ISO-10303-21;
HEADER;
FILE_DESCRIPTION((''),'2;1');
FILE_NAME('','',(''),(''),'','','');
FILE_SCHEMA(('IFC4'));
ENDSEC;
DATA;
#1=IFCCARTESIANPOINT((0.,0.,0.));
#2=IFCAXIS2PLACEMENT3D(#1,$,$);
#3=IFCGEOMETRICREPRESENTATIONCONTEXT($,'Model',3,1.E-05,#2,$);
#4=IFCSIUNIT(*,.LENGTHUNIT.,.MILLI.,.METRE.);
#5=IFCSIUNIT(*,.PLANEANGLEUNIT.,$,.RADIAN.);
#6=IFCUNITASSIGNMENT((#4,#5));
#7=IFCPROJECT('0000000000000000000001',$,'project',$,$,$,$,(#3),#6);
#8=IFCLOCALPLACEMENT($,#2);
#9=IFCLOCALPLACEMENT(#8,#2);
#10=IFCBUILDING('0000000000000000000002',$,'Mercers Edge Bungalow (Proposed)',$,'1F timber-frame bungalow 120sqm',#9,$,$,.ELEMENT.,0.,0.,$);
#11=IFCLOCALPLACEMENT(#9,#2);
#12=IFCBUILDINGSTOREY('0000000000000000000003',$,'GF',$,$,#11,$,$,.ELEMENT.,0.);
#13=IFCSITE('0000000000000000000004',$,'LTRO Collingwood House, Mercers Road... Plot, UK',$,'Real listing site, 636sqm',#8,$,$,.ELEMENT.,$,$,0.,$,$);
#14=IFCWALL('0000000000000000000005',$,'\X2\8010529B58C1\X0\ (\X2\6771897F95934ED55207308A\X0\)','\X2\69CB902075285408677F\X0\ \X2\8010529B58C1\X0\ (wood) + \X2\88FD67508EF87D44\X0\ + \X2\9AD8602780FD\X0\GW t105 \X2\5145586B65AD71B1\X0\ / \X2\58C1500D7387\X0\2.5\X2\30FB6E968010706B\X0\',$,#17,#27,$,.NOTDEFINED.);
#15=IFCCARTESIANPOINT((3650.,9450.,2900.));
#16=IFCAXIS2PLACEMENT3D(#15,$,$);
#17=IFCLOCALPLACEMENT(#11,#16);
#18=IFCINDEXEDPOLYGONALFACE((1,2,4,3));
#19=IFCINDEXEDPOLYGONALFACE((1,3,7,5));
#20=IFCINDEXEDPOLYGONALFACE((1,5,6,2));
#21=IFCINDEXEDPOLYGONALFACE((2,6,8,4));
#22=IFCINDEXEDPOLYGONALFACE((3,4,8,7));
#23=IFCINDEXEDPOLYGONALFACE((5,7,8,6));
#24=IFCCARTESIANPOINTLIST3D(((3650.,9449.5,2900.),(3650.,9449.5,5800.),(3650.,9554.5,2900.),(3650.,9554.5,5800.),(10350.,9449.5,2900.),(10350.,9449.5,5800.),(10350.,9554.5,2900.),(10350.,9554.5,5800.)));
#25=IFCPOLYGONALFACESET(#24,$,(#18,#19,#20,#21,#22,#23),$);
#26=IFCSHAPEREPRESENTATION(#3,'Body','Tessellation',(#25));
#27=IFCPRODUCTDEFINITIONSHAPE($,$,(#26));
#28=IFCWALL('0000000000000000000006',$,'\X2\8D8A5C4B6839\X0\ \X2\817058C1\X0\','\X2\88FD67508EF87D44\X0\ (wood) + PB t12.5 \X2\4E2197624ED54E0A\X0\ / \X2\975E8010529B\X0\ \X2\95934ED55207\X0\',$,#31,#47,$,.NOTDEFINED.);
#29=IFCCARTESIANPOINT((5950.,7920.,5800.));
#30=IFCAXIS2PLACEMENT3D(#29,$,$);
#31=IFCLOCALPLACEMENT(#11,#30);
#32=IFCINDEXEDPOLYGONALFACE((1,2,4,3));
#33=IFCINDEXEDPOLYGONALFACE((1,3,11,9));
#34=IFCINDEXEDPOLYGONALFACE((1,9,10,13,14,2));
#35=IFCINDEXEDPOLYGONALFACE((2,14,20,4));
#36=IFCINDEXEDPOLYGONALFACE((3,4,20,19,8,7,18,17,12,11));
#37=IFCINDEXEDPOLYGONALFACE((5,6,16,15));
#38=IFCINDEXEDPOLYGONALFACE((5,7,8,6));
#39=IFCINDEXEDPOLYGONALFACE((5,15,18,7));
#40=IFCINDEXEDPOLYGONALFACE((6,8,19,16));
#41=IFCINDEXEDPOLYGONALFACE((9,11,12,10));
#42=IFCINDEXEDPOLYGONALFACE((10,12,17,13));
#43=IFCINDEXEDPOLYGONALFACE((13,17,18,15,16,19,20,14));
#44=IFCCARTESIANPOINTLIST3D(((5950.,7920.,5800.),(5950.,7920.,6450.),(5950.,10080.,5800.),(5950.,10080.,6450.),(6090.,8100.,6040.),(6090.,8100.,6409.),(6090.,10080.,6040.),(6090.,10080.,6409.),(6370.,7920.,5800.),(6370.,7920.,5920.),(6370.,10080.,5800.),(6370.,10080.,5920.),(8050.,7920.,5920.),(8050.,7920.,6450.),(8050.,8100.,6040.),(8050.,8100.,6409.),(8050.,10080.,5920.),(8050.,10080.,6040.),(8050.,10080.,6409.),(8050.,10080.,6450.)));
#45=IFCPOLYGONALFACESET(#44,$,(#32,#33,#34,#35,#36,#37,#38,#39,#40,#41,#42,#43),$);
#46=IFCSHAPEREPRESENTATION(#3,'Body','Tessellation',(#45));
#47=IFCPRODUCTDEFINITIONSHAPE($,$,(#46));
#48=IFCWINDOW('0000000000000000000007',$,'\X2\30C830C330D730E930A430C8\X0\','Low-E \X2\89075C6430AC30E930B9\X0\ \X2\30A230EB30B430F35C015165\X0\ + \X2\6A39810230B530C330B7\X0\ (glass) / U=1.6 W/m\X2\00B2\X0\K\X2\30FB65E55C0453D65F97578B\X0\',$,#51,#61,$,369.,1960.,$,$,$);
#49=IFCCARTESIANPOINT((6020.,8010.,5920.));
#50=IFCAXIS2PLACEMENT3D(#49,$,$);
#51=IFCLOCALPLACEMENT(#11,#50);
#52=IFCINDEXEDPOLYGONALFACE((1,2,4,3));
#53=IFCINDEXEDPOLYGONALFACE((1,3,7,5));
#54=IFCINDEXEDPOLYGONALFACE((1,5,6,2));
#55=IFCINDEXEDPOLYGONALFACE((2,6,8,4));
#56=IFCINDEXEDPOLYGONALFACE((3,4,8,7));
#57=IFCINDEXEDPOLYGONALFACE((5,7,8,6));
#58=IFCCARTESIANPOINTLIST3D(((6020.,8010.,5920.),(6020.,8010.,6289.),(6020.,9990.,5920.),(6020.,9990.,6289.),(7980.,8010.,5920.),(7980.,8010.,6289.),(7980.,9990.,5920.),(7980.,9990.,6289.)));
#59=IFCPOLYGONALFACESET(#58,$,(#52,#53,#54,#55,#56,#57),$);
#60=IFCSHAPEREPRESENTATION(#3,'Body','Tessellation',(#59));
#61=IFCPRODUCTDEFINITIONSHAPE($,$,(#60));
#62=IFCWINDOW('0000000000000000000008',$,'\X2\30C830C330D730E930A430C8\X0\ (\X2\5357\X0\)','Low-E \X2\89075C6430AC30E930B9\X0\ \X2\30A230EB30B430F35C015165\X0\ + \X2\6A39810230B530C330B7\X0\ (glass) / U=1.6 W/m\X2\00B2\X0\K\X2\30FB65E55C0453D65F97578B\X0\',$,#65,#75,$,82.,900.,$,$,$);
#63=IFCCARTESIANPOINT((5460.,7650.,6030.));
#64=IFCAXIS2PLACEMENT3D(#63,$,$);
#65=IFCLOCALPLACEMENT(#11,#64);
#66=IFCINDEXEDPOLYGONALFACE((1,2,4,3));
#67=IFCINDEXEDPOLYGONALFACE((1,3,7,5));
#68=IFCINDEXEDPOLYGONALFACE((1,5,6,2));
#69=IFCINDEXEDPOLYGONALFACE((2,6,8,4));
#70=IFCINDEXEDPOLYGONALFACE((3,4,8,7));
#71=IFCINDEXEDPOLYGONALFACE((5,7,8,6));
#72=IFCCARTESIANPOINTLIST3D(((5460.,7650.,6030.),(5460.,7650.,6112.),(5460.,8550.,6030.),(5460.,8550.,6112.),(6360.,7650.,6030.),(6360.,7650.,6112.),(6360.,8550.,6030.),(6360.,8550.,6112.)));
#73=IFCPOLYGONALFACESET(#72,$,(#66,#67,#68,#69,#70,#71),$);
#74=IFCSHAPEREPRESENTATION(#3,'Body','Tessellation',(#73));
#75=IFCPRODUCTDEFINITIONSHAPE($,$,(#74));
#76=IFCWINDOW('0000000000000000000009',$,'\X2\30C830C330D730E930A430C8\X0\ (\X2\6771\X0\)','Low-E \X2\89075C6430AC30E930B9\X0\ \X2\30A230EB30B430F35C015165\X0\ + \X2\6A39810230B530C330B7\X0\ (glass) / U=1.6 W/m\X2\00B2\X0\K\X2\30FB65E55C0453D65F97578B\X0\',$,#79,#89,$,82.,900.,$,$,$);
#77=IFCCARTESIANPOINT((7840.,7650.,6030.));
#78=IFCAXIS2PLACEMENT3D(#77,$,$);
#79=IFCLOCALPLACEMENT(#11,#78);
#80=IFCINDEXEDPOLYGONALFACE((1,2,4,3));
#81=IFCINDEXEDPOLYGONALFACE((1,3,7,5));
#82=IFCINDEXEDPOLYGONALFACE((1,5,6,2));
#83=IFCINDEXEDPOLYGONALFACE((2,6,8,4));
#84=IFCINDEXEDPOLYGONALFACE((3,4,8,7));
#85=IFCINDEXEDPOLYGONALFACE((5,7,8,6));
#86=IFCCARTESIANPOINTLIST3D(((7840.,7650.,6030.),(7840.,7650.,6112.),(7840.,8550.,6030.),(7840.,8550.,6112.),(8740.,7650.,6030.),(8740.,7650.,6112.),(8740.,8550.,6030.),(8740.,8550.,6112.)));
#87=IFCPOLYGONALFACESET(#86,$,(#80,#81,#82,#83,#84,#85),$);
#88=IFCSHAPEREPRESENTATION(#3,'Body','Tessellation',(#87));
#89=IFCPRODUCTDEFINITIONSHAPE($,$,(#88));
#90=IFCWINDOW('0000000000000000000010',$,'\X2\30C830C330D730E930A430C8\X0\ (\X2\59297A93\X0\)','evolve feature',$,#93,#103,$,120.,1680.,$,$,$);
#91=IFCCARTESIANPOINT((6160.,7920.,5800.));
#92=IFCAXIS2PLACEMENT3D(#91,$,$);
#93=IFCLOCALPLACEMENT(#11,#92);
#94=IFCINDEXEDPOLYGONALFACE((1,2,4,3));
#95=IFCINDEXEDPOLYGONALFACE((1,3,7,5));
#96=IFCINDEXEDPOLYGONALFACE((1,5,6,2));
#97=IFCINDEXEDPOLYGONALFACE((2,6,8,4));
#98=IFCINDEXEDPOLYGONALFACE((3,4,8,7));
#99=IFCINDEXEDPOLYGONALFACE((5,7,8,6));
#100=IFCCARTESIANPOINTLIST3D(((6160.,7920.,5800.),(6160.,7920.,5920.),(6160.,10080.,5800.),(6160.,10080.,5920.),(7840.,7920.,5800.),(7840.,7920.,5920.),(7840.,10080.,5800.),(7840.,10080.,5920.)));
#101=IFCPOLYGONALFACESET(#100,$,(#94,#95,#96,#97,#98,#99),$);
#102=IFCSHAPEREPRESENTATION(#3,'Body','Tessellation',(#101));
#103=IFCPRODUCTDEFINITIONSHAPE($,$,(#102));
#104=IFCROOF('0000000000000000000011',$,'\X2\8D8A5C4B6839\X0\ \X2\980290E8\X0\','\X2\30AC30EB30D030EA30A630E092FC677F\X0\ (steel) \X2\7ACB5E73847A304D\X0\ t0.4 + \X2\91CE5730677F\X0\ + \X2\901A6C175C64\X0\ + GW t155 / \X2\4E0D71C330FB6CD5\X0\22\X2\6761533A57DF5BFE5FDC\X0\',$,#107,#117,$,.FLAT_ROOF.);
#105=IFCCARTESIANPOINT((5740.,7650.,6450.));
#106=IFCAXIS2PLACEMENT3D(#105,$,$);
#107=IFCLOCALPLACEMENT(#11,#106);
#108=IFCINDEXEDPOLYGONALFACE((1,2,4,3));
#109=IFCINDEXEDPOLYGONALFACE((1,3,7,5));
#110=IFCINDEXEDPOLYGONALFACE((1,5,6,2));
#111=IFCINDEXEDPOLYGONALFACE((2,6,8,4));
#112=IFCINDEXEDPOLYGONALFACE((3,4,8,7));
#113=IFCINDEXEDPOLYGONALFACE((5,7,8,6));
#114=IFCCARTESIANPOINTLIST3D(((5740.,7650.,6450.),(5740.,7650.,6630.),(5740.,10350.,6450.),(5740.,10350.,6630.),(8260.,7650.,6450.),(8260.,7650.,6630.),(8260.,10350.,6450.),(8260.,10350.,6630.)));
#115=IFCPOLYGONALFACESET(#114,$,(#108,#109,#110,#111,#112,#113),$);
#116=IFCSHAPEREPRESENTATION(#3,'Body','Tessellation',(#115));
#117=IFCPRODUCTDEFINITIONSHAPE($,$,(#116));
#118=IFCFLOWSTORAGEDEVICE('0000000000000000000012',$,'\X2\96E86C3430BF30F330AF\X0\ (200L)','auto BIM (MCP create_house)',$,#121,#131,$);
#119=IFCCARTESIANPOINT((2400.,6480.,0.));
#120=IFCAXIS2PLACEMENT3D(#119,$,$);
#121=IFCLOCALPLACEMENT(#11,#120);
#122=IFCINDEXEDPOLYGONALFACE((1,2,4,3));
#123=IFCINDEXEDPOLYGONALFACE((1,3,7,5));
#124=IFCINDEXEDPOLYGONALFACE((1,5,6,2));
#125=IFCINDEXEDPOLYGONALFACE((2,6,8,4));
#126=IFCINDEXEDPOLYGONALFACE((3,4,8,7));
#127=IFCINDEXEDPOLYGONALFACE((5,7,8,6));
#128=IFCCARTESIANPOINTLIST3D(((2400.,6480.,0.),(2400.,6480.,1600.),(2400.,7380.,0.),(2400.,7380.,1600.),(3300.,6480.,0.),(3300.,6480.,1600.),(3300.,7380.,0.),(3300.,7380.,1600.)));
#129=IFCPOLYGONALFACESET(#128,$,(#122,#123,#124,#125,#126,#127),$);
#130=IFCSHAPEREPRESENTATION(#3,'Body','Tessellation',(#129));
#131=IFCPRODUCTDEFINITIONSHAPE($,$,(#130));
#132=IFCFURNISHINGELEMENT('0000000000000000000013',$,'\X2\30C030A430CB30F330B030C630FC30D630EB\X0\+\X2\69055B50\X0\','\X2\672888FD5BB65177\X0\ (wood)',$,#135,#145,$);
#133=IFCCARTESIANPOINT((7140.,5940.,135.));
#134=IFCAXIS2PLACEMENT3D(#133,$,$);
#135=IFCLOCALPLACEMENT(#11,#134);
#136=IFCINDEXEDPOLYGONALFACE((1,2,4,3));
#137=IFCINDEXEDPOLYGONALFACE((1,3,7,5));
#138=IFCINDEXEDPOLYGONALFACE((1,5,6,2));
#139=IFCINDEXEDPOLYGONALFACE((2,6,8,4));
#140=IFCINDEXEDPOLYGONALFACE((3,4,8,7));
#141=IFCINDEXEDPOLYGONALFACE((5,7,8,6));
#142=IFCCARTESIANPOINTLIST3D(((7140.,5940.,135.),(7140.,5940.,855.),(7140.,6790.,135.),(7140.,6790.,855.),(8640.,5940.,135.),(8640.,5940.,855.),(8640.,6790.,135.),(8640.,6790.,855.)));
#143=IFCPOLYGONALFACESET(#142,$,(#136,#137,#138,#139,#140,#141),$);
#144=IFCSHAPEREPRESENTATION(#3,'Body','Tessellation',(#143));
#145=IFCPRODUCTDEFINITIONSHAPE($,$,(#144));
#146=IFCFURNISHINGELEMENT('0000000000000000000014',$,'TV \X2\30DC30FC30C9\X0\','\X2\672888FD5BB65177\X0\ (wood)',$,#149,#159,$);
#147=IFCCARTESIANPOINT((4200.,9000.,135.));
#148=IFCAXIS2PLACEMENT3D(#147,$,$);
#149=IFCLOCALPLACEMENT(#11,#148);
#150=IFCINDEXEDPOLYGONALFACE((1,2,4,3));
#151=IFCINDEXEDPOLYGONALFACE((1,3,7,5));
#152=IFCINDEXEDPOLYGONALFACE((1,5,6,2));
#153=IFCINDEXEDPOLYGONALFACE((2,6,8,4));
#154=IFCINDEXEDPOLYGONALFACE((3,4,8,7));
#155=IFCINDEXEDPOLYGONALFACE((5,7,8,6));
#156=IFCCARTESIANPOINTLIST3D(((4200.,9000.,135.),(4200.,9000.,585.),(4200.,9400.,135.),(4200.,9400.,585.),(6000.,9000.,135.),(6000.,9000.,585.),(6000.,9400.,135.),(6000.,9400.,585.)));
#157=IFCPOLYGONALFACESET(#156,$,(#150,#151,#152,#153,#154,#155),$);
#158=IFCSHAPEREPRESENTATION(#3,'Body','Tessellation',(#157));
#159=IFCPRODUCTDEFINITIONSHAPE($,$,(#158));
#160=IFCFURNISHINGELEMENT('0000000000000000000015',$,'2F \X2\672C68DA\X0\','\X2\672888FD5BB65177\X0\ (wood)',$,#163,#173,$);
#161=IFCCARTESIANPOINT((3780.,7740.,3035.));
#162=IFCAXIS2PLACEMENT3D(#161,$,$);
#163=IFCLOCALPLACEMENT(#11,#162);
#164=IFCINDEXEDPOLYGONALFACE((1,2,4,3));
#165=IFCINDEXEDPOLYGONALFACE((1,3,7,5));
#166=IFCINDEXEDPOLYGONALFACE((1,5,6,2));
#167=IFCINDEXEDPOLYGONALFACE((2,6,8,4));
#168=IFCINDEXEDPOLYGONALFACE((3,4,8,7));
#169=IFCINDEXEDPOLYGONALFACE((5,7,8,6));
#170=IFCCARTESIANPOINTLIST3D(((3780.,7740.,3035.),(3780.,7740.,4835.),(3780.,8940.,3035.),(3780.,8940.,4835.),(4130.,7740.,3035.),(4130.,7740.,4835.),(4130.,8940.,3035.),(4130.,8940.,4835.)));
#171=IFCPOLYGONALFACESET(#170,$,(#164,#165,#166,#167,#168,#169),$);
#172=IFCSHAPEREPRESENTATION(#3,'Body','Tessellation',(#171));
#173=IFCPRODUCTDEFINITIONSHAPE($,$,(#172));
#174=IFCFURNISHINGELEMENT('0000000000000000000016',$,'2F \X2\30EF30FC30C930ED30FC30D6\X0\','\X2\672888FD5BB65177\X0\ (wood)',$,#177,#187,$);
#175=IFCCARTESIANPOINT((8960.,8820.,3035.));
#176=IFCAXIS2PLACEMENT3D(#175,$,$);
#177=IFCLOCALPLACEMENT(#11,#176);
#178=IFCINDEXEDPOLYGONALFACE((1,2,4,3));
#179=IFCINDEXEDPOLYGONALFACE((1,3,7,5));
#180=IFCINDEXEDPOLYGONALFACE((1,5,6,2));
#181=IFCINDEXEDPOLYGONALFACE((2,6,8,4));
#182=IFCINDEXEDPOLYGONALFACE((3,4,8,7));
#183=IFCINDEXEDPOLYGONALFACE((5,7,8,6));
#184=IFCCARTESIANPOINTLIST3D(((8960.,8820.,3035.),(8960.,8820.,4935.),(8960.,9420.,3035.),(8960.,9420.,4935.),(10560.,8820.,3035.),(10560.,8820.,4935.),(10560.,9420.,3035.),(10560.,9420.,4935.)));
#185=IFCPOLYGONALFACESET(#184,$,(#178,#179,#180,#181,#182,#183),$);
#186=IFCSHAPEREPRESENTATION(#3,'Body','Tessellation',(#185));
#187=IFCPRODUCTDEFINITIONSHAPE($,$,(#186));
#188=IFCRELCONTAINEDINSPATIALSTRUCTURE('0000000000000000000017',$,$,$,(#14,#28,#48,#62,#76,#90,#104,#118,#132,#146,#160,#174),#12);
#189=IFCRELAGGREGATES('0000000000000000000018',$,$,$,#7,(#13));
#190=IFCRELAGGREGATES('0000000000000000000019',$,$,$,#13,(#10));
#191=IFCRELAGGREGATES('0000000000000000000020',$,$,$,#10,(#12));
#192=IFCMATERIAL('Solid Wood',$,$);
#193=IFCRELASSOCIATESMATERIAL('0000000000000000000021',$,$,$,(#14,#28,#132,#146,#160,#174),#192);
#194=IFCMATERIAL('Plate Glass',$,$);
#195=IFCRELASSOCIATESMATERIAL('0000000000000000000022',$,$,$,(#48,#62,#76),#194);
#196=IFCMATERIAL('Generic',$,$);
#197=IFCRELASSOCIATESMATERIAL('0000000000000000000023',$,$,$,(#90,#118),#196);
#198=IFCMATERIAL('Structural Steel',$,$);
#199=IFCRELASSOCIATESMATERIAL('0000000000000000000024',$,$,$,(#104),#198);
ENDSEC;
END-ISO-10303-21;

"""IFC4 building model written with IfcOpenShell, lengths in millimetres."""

from ifc_helpers import new_model, si_unit, frame, frame_2d, origin, place, context, project, spatial, rectangle, extrude, material, element, fill, save


model = new_model("IFC4")

# Units and contexts
model_context = context("Model", 3, precision=1e-05, world=origin())
ifc_project = project(units=[si_unit("LENGTHUNIT", "METRE", prefix="MILLI"), si_unit("PLANEANGLEUNIT", "RADIAN")], contexts=[model_context])

# Site, building, storey
site_placement = place(None, origin())
site = spatial("IfcSite", under=ifc_project, at=site_placement, Name="LTRO Collingwood House, Mercers Road... Plot, UK", ObjectType="Real listing site, 636sqm", CompositionType="ELEMENT", RefElevation=0.0)
building_placement = place(site_placement, origin())
building = spatial("IfcBuilding", under=site, at=building_placement, Name="Mercers Edge Bungalow (Proposed)", ObjectType="1F timber-frame bungalow 120sqm", CompositionType="ELEMENT", ElevationOfRefHeight=0.0, ElevationOfTerrain=0.0)
storey_placement = place(building_placement, origin())
storey = spatial("IfcBuildingStorey", under=building, at=storey_placement, Name="GF", CompositionType="ELEMENT", Elevation=0.0)

# Wall
ifc_material_1 = material(Name="Solid Wood")
wall_1_placement = place(storey_placement, frame((3650.0, 9450.0, 2900.0)))
element("IfcWall", 1, at=wall_1_placement, inside=storey, material=ifc_material_1, Name="耐力壁 (東西間仕切り)", Description="構造用合板 耐力壁 (wood) + 製材軸組 + 高性能GW t105 充填断熱 / 壁倍率2.5・準耐火", PredefinedType="NOTDEFINED", context=model_context, shape_type="SweptSolid", body=[
    extrude(rectangle(XDim=6700.0, YDim=105.0, at=frame_2d((3350.0, 52.0))), frame((3650.0, 9450.0, 2900.0)), (0.0, 0.0, 1.0), 2900.0),
])

# Wall, openings, windows
wall_2_placement = place(storey_placement, frame((5950.0, 7920.0, 5800.0)))
wall_2 = element("IfcWall", 2, at=wall_2_placement, inside=storey, material=ifc_material_1, Name="越屋根 腰壁", Description="製材軸組 (wood) + PB t12.5 両面仕上 / 非耐力 間仕切", PredefinedType="NOTDEFINED", context=model_context, shape_type="SweptSolid", body=[
    extrude(rectangle(XDim=2100.0, YDim=2160.0, at=frame_2d((1050.0, 1080.0))), frame((5950.0, 7920.0, 5800.0)), (0.0, 0.0, 1.0), 650.0),
])
opening_1_placement = place(storey_placement, frame((6020.0, 8010.0, 5920.0)))
opening_1 = element("IfcOpeningElement", 3, at=opening_1_placement, cuts=wall_2, PredefinedType="NOTDEFINED", context=model_context, shape_type="SweptSolid", body=[
    extrude(rectangle(XDim=1960.0, YDim=1980.0, at=frame_2d((980.0, 990.0))), frame((6020.0, 8010.0, 5920.0)), (0.0, 0.0, 1.0), 369.0),
])
opening_2_placement = place(storey_placement, frame((5460.0, 7650.0, 6030.0)))
opening_2 = element("IfcOpeningElement", 4, at=opening_2_placement, cuts=wall_2, PredefinedType="NOTDEFINED", context=model_context, shape_type="SweptSolid", body=[
    extrude(rectangle(XDim=900.0, YDim=900.0, at=frame_2d((450.0, 450.0))), frame((5460.0, 7650.0, 6030.0)), (0.0, 0.0, 1.0), 82.0),
])
opening_3_placement = place(storey_placement, frame((7840.0, 7650.0, 6030.0)))
opening_3 = element("IfcOpeningElement", 5, at=opening_3_placement, cuts=wall_2, PredefinedType="NOTDEFINED", context=model_context, shape_type="SweptSolid", body=[
    extrude(rectangle(XDim=900.0, YDim=900.0, at=frame_2d((450.0, 450.0))), frame((7840.0, 7650.0, 6030.0)), (0.0, 0.0, 1.0), 82.0),
])
opening_4_placement = place(storey_placement, frame((6160.0, 7920.0, 5800.0)))
opening_4 = element("IfcOpeningElement", 6, at=opening_4_placement, cuts=wall_2, PredefinedType="NOTDEFINED", context=model_context, shape_type="SweptSolid", body=[
    extrude(rectangle(XDim=1680.0, YDim=2160.0, at=frame_2d((840.0, 1080.0))), frame((6160.0, 7920.0, 5800.0)), (0.0, 0.0, 1.0), 120.0),
])
ifc_material_2 = material(Name="Plate Glass")
window_1_placement = place(storey_placement, frame((6020.0, 8010.0, 5920.0)))
window_1 = element("IfcWindow", 7, at=window_1_placement, inside=storey, material=ifc_material_2, Name="トップライト", Description="Low-E 複層ガラス アルゴン封入 + 樹脂サッシ (glass) / U=1.6 W/m²K・日射取得型", OverallHeight=369.0, OverallWidth=1960.0, context=model_context, shape_type="SweptSolid", body=[
    extrude(rectangle(XDim=1960.0, YDim=1980.0, at=frame_2d((980.0, 990.0))), frame((6020.0, 8010.0, 5920.0)), (0.0, 0.0, 1.0), 369.0),
])
fill(opening_1, window_1)
window_2_placement = place(storey_placement, frame((5460.0, 7650.0, 6030.0)))
window_2 = element("IfcWindow", 8, at=window_2_placement, inside=storey, material=ifc_material_2, Name="トップライト (南)", Description="Low-E 複層ガラス アルゴン封入 + 樹脂サッシ (glass) / U=1.6 W/m²K・日射取得型", OverallHeight=82.0, OverallWidth=900.0, context=model_context, shape_type="SweptSolid", body=[
    extrude(rectangle(XDim=900.0, YDim=900.0, at=frame_2d((450.0, 450.0))), frame((5460.0, 7650.0, 6030.0)), (0.0, 0.0, 1.0), 82.0),
])
fill(opening_2, window_2)
window_3_placement = place(storey_placement, frame((7840.0, 7650.0, 6030.0)))
window_3 = element("IfcWindow", 9, at=window_3_placement, inside=storey, material=ifc_material_2, Name="トップライト (東)", Description="Low-E 複層ガラス アルゴン封入 + 樹脂サッシ (glass) / U=1.6 W/m²K・日射取得型", OverallHeight=82.0, OverallWidth=900.0, context=model_context, shape_type="SweptSolid", body=[
    extrude(rectangle(XDim=900.0, YDim=900.0, at=frame_2d((450.0, 450.0))), frame((7840.0, 7650.0, 6030.0)), (0.0, 0.0, 1.0), 82.0),
])
fill(opening_3, window_3)
ifc_material_3 = material(Name="Generic")
window_4_placement = place(storey_placement, frame((6160.0, 7920.0, 5800.0)))
window_4 = element("IfcWindow", 10, at=window_4_placement, inside=storey, material=ifc_material_3, Name="トップライト (天窓)", Description="evolve feature", OverallHeight=120.0, OverallWidth=1680.0, context=model_context, shape_type="SweptSolid", body=[
    extrude(rectangle(XDim=1680.0, YDim=2160.0, at=frame_2d((840.0, 1080.0))), frame((6160.0, 7920.0, 5800.0)), (0.0, 0.0, 1.0), 120.0),
])
fill(opening_4, window_4)

# Roof
ifc_material_4 = material(Name="Structural Steel")
roof_placement = place(storey_placement, frame((5740.0, 7650.0, 6450.0)))
element("IfcRoof", 11, at=roof_placement, inside=storey, material=ifc_material_4, Name="越屋根 頂部", Description="ガルバリウム鋼板 (steel) 立平葺き t0.4 + 野地板 + 通気層 + GW t155 / 不燃・法22条区域対応", PredefinedType="FLAT_ROOF", context=model_context, shape_type="SweptSolid", body=[
    extrude(rectangle(XDim=2520.0, YDim=2700.0, at=frame_2d((1260.0, 1350.0))), frame((5740.0, 7650.0, 6450.0)), (0.0, 0.0, 1.0), 180.0),
])

# Flow storage device
flow_storage_device_placement = place(storey_placement, frame((2400.0, 6480.0, 0.0)))
element("IfcFlowStorageDevice", 12, at=flow_storage_device_placement, inside=storey, material=ifc_material_3, Name="雨水タンク (200L)", Description="auto BIM (MCP create_house)", context=model_context, shape_type="SweptSolid", body=[
    extrude(rectangle(XDim=900.0, YDim=900.0, at=frame_2d((450.0, 450.0))), frame((2400.0, 6480.0, 0.0)), (0.0, 0.0, 1.0), 1600.0),
])

# Furnishing elements
furnishing_1_placement = place(storey_placement, frame((7140.0, 5940.0, 135.0)))
element("IfcFurnishingElement", 13, at=furnishing_1_placement, inside=storey, material=ifc_material_1, Name="ダイニングテーブル+椅子", Description="木製家具 (wood)", context=model_context, shape_type="SweptSolid", body=[
    extrude(rectangle(XDim=1500.0, YDim=850.0, at=frame_2d((750.0, 425.0))), frame((7140.0, 5940.0, 135.0)), (0.0, 0.0, 1.0), 720.0),
])
furnishing_2_placement = place(storey_placement, frame((4200.0, 9000.0, 135.0)))
element("IfcFurnishingElement", 14, at=furnishing_2_placement, inside=storey, material=ifc_material_1, Name="TV ボード", Description="木製家具 (wood)", context=model_context, shape_type="SweptSolid", body=[
    extrude(rectangle(XDim=1800.0, YDim=400.0, at=frame_2d((900.0, 200.0))), frame((4200.0, 9000.0, 135.0)), (0.0, 0.0, 1.0), 450.0),
])
furnishing_3_placement = place(storey_placement, frame((3780.0, 7740.0, 3035.0)))
element("IfcFurnishingElement", 15, at=furnishing_3_placement, inside=storey, material=ifc_material_1, Name="2F 本棚", Description="木製家具 (wood)", context=model_context, shape_type="SweptSolid", body=[
    extrude(rectangle(XDim=350.0, YDim=1200.0, at=frame_2d((175.0, 600.0))), frame((3780.0, 7740.0, 3035.0)), (0.0, 0.0, 1.0), 1800.0),
])
furnishing_4_placement = place(storey_placement, frame((8960.0, 8820.0, 3035.0)))
element("IfcFurnishingElement", 16, at=furnishing_4_placement, inside=storey, material=ifc_material_1, Name="2F ワードローブ", Description="木製家具 (wood)", context=model_context, shape_type="SweptSolid", body=[
    extrude(rectangle(XDim=1600.0, YDim=600.0, at=frame_2d((800.0, 300.0))), frame((8960.0, 8820.0, 3035.0)), (0.0, 0.0, 1.0), 1900.0),
])

save(model, "model.ifc")
